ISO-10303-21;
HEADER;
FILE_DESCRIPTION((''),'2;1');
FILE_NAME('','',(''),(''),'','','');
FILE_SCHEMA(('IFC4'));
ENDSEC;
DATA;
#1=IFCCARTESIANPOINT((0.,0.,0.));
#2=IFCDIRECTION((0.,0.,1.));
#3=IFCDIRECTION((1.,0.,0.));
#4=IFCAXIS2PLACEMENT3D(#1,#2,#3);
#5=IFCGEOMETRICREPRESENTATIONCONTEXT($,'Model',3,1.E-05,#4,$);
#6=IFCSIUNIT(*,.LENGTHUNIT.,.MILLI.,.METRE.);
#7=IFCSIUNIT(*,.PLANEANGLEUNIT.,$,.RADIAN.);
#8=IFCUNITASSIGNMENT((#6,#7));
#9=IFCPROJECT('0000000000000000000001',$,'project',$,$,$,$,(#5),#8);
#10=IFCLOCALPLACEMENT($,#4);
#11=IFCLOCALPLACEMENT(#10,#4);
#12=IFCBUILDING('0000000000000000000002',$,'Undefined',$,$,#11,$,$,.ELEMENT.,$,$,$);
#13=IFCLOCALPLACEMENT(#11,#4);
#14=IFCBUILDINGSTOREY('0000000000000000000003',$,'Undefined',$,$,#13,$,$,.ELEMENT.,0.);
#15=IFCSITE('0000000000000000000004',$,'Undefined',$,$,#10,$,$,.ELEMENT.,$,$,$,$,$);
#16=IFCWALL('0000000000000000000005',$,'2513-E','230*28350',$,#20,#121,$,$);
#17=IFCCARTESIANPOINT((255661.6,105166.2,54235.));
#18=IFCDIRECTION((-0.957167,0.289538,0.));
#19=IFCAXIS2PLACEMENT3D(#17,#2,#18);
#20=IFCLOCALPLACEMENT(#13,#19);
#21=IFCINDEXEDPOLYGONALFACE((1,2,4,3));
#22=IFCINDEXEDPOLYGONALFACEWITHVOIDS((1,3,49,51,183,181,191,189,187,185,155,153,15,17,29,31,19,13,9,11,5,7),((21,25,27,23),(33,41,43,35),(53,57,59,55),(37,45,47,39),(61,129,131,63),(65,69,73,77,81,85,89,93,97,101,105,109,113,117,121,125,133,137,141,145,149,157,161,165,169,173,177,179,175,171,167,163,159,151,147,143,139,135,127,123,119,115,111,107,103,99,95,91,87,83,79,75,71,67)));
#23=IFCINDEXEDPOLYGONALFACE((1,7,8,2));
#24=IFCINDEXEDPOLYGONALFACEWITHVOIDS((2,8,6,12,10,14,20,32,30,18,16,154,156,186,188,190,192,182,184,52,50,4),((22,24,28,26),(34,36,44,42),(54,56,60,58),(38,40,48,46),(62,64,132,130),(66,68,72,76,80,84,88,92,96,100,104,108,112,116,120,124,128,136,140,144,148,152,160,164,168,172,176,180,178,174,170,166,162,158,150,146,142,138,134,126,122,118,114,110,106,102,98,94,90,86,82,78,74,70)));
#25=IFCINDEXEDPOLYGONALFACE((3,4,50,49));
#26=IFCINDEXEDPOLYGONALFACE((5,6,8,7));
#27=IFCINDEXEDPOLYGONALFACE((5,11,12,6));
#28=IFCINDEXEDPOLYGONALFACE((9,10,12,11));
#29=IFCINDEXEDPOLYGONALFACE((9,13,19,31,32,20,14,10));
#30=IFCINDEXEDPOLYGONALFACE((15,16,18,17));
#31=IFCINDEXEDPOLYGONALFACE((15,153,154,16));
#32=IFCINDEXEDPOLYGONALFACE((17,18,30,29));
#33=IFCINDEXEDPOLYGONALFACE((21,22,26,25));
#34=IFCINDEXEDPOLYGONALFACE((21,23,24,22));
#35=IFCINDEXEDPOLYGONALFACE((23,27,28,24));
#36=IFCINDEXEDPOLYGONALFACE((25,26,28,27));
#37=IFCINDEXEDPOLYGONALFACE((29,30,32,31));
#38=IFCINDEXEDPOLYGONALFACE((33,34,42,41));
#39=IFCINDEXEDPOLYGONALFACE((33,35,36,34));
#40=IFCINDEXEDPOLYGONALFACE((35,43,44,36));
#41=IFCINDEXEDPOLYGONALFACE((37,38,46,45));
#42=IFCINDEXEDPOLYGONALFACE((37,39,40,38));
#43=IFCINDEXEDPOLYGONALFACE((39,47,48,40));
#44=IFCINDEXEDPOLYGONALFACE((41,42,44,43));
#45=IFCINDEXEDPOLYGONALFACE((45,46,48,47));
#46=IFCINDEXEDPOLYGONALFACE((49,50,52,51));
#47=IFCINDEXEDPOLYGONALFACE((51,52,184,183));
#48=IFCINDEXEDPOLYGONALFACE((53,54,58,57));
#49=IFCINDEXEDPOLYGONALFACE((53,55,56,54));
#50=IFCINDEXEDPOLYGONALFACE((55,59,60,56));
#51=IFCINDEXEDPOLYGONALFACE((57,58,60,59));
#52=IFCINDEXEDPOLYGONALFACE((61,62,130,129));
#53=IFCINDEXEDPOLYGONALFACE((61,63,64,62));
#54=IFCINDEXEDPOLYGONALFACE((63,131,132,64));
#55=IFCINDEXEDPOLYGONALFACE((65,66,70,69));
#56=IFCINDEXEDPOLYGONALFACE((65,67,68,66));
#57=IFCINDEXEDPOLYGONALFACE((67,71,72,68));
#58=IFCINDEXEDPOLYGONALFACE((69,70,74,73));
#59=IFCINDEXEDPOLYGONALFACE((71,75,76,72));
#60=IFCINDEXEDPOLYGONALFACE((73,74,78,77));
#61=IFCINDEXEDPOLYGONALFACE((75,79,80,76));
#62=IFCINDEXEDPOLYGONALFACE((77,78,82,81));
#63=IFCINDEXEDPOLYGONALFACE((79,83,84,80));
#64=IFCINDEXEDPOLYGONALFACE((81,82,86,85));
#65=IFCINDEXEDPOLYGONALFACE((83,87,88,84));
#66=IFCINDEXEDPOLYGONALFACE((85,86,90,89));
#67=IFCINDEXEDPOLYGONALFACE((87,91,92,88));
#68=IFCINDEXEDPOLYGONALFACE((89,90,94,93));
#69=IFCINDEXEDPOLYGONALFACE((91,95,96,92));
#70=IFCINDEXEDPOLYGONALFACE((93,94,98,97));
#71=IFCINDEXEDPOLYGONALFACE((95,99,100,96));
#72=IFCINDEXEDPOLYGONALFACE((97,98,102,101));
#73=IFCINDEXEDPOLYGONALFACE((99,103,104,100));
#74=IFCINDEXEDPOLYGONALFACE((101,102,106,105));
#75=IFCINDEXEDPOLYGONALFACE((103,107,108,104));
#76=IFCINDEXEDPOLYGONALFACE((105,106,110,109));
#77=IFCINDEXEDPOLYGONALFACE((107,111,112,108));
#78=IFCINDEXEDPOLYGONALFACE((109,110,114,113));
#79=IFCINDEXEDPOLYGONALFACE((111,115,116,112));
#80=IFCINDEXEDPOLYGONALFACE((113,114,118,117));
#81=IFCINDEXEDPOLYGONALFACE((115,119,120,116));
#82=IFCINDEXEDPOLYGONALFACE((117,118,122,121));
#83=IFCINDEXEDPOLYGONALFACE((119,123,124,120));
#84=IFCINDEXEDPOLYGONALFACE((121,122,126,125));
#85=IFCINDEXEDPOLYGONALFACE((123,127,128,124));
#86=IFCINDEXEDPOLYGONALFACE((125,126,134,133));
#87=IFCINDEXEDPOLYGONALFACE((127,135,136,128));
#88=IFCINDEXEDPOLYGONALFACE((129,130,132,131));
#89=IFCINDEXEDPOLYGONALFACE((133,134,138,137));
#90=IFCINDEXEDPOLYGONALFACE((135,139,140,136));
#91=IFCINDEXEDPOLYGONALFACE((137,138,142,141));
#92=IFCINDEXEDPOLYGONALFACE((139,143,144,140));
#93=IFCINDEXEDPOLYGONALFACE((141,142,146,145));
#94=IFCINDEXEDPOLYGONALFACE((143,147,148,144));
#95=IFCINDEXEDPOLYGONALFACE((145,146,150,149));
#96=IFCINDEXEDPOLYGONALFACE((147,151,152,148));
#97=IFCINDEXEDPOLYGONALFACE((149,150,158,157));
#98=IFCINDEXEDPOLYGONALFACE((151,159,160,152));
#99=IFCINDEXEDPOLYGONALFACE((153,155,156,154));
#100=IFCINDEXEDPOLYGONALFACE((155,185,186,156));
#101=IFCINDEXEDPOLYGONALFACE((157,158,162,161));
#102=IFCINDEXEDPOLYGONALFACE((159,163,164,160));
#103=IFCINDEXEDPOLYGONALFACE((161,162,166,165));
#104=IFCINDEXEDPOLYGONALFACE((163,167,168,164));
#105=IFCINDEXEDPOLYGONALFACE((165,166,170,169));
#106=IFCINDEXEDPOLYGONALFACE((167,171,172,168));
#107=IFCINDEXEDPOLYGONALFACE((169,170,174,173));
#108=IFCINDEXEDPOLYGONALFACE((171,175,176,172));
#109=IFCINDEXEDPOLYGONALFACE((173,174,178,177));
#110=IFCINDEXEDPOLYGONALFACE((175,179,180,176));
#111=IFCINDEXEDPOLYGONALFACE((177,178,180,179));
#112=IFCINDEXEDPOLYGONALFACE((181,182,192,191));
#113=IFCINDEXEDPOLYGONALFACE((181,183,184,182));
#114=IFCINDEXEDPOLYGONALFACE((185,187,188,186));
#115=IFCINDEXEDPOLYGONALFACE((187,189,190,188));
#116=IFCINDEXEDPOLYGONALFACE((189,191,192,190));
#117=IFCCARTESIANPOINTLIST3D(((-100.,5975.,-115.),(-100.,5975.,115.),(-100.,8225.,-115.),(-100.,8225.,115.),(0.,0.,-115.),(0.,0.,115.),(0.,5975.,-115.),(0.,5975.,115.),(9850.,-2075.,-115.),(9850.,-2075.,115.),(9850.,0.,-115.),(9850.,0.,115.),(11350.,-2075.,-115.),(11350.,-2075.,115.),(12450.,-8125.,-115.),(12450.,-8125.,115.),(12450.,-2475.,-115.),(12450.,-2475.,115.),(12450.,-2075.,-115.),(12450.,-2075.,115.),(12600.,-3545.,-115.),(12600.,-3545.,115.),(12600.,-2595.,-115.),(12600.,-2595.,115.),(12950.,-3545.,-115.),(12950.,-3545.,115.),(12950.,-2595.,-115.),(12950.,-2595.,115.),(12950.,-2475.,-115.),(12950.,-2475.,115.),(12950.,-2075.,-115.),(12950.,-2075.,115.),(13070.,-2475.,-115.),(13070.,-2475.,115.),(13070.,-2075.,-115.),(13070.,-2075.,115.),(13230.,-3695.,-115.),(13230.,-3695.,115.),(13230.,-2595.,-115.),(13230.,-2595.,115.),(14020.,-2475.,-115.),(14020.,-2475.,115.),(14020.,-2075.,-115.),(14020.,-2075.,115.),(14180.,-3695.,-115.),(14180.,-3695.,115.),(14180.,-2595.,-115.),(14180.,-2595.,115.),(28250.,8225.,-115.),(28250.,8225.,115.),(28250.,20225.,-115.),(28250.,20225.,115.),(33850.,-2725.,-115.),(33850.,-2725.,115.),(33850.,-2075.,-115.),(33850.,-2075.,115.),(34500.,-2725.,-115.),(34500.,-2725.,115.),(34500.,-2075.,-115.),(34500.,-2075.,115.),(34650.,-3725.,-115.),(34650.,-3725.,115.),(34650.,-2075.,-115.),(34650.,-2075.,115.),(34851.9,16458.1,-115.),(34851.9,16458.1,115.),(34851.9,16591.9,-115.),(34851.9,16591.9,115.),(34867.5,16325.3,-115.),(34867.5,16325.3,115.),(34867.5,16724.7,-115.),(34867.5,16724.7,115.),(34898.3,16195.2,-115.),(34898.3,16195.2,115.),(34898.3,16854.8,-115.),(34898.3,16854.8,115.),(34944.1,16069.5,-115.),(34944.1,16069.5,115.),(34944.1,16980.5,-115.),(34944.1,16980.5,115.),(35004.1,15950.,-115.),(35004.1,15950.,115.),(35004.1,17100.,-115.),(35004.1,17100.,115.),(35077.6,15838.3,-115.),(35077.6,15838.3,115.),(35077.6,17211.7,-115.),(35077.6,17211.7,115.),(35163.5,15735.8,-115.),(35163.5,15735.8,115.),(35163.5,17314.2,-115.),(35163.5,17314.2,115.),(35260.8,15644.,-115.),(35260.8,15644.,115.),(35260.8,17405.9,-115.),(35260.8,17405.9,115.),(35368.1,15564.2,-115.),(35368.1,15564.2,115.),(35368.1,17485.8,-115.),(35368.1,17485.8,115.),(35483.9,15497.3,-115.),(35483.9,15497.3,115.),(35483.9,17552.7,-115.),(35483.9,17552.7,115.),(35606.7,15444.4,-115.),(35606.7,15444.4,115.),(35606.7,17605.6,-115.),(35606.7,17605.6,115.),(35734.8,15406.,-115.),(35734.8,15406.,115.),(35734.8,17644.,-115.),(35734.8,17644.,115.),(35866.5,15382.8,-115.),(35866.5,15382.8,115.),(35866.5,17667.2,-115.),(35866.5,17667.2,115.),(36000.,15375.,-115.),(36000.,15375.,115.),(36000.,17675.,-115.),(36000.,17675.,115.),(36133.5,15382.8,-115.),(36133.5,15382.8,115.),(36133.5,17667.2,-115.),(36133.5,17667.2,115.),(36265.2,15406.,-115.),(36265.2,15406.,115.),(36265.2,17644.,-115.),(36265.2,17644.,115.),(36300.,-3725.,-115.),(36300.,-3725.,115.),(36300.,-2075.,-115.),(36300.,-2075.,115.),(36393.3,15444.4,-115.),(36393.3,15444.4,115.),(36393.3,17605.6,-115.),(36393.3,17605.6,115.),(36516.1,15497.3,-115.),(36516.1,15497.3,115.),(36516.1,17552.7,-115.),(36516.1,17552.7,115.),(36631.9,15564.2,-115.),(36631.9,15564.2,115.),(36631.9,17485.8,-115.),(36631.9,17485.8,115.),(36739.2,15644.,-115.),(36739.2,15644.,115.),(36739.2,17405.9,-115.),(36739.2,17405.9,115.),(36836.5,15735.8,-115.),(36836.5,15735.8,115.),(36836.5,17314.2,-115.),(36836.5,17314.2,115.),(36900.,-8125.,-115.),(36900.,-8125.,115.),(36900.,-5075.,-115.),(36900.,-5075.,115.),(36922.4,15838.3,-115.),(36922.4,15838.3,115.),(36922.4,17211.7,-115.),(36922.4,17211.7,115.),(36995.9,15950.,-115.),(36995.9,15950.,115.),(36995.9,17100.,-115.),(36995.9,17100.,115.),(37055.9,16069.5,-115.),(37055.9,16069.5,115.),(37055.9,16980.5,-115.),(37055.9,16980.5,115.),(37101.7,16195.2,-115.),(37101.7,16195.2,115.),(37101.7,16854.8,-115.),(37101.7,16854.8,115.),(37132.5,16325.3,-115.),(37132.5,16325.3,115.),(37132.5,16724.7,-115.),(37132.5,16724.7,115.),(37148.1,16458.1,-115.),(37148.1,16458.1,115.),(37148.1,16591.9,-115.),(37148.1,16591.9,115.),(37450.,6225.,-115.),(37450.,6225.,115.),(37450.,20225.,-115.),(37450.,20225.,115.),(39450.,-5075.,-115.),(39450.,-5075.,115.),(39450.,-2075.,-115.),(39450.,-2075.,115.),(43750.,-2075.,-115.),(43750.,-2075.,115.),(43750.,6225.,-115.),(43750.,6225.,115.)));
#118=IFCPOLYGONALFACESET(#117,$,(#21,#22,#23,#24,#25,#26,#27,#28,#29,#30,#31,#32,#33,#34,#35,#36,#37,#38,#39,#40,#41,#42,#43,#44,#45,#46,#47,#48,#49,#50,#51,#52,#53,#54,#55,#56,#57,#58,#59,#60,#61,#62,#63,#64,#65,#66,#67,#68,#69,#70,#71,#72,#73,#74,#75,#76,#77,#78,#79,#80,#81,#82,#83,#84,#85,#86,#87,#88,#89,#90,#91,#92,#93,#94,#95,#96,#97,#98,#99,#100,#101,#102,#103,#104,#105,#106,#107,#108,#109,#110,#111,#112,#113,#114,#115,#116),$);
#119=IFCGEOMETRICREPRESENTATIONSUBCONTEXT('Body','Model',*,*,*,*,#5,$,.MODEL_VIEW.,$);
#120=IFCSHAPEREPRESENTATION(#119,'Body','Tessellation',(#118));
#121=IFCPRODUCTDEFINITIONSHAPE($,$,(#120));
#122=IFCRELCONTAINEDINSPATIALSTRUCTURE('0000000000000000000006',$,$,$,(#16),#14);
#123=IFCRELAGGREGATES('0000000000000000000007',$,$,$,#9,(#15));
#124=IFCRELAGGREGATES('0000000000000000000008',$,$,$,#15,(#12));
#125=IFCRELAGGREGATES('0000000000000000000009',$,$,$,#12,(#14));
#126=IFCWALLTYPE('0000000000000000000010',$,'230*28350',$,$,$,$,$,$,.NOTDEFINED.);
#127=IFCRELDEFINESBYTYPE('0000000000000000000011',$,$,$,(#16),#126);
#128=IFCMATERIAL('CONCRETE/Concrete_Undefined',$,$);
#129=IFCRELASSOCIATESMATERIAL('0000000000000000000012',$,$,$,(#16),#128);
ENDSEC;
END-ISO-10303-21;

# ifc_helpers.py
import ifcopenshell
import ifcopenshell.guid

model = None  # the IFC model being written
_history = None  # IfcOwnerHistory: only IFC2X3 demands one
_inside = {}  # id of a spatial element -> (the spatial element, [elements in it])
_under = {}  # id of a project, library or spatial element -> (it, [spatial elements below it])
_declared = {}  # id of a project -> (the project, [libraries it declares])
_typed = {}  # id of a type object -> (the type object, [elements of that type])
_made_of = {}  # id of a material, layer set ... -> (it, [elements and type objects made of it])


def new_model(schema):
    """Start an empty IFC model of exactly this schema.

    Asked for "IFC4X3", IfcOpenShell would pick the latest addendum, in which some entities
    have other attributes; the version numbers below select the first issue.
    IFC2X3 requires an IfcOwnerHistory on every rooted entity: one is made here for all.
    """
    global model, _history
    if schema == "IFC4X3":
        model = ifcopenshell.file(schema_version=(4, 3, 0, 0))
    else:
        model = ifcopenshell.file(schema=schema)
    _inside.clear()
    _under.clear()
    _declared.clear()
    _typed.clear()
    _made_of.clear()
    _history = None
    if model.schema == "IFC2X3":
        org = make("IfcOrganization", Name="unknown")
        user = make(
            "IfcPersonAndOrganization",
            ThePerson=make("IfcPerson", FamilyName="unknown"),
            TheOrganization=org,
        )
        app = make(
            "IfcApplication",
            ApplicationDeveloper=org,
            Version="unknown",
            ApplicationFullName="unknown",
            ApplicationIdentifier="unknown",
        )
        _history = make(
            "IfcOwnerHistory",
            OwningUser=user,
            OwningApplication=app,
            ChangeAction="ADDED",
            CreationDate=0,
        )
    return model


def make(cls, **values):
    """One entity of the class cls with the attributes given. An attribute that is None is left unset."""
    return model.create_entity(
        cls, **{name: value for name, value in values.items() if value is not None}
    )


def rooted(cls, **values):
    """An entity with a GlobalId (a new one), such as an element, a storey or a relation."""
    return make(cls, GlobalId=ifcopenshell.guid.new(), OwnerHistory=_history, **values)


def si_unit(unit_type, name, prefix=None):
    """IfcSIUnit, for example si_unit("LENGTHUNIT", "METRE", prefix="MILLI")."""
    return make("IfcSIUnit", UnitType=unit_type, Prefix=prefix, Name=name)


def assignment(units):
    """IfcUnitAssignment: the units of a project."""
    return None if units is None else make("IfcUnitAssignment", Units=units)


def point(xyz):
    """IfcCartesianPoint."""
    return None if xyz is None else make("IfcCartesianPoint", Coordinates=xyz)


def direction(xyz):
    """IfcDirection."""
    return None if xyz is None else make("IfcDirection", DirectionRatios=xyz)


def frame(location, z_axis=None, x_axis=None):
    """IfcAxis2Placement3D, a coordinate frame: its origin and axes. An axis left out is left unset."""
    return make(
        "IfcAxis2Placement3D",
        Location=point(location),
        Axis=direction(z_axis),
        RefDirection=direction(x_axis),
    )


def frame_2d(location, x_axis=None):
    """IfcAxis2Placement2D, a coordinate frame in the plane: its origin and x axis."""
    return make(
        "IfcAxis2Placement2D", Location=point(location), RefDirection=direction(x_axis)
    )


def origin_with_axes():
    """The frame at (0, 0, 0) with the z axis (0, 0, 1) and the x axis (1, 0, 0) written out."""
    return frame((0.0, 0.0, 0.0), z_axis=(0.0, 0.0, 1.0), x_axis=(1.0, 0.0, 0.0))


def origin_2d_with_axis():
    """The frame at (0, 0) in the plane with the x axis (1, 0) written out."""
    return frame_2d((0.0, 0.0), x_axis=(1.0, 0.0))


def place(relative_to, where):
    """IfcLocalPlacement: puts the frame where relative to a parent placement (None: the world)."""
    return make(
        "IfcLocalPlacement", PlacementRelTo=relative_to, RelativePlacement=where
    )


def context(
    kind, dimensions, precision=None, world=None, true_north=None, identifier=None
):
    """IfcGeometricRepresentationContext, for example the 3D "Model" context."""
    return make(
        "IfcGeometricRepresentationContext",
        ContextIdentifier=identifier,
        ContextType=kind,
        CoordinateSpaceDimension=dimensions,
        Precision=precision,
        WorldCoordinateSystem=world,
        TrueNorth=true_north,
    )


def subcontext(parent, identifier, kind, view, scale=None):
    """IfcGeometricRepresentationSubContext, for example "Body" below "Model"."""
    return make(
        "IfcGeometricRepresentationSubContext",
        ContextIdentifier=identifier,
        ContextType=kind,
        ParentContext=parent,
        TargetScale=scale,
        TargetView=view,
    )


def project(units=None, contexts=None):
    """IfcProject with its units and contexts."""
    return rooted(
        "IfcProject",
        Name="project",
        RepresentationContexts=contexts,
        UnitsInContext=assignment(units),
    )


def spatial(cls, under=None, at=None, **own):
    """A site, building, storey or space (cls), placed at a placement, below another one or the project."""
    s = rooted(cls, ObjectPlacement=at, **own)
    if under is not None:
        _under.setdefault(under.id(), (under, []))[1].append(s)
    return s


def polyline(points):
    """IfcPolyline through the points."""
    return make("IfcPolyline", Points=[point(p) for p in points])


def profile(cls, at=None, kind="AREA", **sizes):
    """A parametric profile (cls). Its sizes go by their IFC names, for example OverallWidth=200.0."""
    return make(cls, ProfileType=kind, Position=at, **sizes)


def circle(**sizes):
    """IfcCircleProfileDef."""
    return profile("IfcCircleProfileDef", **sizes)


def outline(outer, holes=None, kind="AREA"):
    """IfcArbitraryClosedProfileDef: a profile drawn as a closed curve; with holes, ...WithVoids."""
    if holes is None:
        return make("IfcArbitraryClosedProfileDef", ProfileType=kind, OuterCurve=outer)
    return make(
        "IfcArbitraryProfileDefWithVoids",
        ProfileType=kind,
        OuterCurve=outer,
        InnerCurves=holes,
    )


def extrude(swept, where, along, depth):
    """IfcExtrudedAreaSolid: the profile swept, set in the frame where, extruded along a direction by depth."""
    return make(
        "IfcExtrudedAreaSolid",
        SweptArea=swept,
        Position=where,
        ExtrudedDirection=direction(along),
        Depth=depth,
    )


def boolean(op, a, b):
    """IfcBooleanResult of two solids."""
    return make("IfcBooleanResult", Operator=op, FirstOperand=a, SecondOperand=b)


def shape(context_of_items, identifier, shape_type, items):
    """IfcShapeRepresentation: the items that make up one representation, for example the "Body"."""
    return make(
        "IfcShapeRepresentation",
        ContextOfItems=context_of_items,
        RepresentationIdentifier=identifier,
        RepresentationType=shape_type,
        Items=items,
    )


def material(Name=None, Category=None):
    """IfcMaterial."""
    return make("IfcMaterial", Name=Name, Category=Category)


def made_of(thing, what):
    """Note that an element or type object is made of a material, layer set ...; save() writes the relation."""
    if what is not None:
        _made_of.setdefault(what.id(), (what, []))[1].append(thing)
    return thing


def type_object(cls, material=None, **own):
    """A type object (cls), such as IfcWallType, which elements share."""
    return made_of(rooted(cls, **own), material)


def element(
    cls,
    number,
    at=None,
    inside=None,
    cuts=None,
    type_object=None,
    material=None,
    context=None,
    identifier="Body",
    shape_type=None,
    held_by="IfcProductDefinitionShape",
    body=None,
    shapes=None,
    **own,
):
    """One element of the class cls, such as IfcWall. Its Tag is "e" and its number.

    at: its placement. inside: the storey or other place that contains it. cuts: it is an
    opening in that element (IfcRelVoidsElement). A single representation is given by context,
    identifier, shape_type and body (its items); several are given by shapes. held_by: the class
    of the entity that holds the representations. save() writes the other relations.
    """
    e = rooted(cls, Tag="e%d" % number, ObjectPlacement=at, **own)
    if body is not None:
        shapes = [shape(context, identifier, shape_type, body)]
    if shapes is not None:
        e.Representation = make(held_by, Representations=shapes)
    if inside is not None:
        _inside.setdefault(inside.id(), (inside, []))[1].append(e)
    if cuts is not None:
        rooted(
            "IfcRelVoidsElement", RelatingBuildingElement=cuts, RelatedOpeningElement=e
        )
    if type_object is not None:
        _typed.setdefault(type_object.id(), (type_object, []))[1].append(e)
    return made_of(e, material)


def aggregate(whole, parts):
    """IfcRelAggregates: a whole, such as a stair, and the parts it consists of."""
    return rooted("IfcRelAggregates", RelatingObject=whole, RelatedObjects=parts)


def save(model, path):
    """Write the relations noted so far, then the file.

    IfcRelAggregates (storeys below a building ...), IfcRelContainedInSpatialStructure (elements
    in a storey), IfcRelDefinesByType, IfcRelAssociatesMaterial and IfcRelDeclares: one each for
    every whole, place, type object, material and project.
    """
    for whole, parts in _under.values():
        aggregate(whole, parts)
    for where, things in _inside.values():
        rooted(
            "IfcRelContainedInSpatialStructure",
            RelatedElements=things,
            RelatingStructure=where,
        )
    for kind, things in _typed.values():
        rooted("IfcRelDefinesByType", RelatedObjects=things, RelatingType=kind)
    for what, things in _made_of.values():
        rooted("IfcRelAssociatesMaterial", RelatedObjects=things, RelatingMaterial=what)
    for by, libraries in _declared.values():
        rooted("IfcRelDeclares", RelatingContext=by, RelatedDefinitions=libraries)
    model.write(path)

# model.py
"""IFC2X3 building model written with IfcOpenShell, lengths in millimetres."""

from ifc_helpers import new_model, si_unit, frame, origin_with_axes, origin_2d_with_axis, place, context, subcontext, project, spatial, polyline, circle, outline, extrude, boolean, material, type_object, element, save


model = new_model("IFC2X3")

# Units and contexts
model_context = context("Model", 3, precision=1e-05, world=origin_with_axes())
body_context = subcontext(model_context, "Body", "Model", "MODEL_VIEW")
ifc_project = project(units=[si_unit("LENGTHUNIT", "METRE", prefix="MILLI"), si_unit("PLANEANGLEUNIT", "RADIAN")], contexts=[model_context])

# Site, building, storey
site_placement = place(None, origin_with_axes())
site = spatial("IfcSite", under=ifc_project, at=site_placement, Name="Undefined", CompositionType="ELEMENT")
building_placement = place(site_placement, origin_with_axes())
building = spatial("IfcBuilding", under=site, at=building_placement, Name="Undefined", CompositionType="ELEMENT")
storey_placement = place(building_placement, origin_with_axes())
storey = spatial("IfcBuildingStorey", under=building, at=storey_placement, Name="Undefined", CompositionType="ELEMENT", Elevation=0.0)

# Shared definitions
ifc_material_1 = material(Name="CONCRETE/Concrete_Undefined")

# Wall
wall_type_1 = type_object("IfcWallType", Name="230*28350", PredefinedType="NOTDEFINED")
wall_1_placement = place(storey_placement, frame((255661.6, 105166.2, 54235.0), z_axis=(0.0, 0.0, 1.0), x_axis=(-0.957167, 0.289538, 0.0)))
element("IfcWall", 1, at=wall_1_placement, inside=storey, type_object=wall_type_1, material=ifc_material_1, Name="2513-E", Description="230*28350", context=body_context, shape_type="CSG", body=[
    boolean("DIFFERENCE", boolean("DIFFERENCE", boolean("DIFFERENCE", boolean("DIFFERENCE", boolean("DIFFERENCE", boolean("DIFFERENCE", boolean("DIFFERENCE", extrude(outline(polyline([(0.0, 0.0), (9850.0, 0.0), (9850.0, -2075.0), (12450.0, -2075.0), (12450.0, -8125.0), (36900.0, -8125.0), (36900.0, -5075.0), (39450.0, -5075.0), (39450.0, -2075.0), (43750.0, -2075.0), (43750.0, 6225.0), (37450.0, 6225.0), (37450.0, 20225.0), (28250.0, 20225.0), (28250.0, 8225.0), (-100.0, 8225.0), (-100.0, 5975.0), (0.0, 5975.0), (0.0, 0.0)])), frame((0.0, 0.0, -115.0), z_axis=(0.0, 0.0, 1.0), x_axis=(1.0, 0.0, 0.0)), (0.0, 0.0, 1.0), 230.0), extrude(circle(Radius=1150.0, at=origin_2d_with_axis()), frame((36000.0, 16525.0, 545.0), z_axis=(0.0, 0.0, -1.0), x_axis=(0.0, -1.0, 0.0)), (0.0, 0.0, 1.0), 1680.0)), extrude(outline(polyline([(0.0, 0.0), (400.0, 0.0), (400.0, 950.0), (0.0, 950.0), (0.0, 0.0)])), frame((14020.0, -2075.0, 265.0), z_axis=(0.0, 0.0, -1.0), x_axis=(0.0, -1.0, 0.0)), (0.0, 0.0, 1.0), 500.0)), extrude(outline(polyline([(0.0, 0.0), (1100.0, 0.0), (1100.0, 950.0), (0.0, 950.0), (0.0, 0.0)])), frame((14180.0, -2595.0, 265.0), z_axis=(0.0, 0.0, -1.0), x_axis=(0.0, -1.0, 0.0)), (0.0, 0.0, 1.0), 500.0)), extrude(outline(polyline([(0.0, 0.0), (950.0, 0.0), (950.0, 350.0), (0.0, 350.0), (0.0, 0.0)])), frame((12950.0, -2595.0, 265.0), z_axis=(0.0, 0.0, -1.0), x_axis=(0.0, -1.0, 0.0)), (0.0, 0.0, 1.0), 500.0)), extrude(outline(polyline([(0.0, 0.0), (650.0, 0.0), (650.0, 650.0), (0.0, 650.0), (0.0, 0.0)])), frame((34500.0, -2725.0, 117.5), z_axis=(0.0, 0.0, -1.0), x_axis=(-1.0, 0.0, 0.0)), (0.0, 0.0, 1.0), 235.0)), extrude(outline(polyline([(0.0, 0.0), (1650.0, 0.0), (1650.0, 1650.0), (0.0, 1650.0), (0.0, 0.0)])), frame((36300.0, -3725.0, 117.5), z_axis=(0.0, 0.0, -1.0), x_axis=(-1.0, 0.0, 0.0)), (0.0, 0.0, 1.0), 235.0)), extrude(outline(polyline([(0.0, 0.0), (400.0, 0.0), (400.0, 1600.0), (0.0, 1600.0), (0.0, 0.0)])), frame((12950.0, -2075.0, 265.0), z_axis=(0.0, 0.0, -1.0), x_axis=(0.0, -1.0, 0.0)), (0.0, 0.0, 1.0), 500.0)),
])

save(model, "model.ifc")
